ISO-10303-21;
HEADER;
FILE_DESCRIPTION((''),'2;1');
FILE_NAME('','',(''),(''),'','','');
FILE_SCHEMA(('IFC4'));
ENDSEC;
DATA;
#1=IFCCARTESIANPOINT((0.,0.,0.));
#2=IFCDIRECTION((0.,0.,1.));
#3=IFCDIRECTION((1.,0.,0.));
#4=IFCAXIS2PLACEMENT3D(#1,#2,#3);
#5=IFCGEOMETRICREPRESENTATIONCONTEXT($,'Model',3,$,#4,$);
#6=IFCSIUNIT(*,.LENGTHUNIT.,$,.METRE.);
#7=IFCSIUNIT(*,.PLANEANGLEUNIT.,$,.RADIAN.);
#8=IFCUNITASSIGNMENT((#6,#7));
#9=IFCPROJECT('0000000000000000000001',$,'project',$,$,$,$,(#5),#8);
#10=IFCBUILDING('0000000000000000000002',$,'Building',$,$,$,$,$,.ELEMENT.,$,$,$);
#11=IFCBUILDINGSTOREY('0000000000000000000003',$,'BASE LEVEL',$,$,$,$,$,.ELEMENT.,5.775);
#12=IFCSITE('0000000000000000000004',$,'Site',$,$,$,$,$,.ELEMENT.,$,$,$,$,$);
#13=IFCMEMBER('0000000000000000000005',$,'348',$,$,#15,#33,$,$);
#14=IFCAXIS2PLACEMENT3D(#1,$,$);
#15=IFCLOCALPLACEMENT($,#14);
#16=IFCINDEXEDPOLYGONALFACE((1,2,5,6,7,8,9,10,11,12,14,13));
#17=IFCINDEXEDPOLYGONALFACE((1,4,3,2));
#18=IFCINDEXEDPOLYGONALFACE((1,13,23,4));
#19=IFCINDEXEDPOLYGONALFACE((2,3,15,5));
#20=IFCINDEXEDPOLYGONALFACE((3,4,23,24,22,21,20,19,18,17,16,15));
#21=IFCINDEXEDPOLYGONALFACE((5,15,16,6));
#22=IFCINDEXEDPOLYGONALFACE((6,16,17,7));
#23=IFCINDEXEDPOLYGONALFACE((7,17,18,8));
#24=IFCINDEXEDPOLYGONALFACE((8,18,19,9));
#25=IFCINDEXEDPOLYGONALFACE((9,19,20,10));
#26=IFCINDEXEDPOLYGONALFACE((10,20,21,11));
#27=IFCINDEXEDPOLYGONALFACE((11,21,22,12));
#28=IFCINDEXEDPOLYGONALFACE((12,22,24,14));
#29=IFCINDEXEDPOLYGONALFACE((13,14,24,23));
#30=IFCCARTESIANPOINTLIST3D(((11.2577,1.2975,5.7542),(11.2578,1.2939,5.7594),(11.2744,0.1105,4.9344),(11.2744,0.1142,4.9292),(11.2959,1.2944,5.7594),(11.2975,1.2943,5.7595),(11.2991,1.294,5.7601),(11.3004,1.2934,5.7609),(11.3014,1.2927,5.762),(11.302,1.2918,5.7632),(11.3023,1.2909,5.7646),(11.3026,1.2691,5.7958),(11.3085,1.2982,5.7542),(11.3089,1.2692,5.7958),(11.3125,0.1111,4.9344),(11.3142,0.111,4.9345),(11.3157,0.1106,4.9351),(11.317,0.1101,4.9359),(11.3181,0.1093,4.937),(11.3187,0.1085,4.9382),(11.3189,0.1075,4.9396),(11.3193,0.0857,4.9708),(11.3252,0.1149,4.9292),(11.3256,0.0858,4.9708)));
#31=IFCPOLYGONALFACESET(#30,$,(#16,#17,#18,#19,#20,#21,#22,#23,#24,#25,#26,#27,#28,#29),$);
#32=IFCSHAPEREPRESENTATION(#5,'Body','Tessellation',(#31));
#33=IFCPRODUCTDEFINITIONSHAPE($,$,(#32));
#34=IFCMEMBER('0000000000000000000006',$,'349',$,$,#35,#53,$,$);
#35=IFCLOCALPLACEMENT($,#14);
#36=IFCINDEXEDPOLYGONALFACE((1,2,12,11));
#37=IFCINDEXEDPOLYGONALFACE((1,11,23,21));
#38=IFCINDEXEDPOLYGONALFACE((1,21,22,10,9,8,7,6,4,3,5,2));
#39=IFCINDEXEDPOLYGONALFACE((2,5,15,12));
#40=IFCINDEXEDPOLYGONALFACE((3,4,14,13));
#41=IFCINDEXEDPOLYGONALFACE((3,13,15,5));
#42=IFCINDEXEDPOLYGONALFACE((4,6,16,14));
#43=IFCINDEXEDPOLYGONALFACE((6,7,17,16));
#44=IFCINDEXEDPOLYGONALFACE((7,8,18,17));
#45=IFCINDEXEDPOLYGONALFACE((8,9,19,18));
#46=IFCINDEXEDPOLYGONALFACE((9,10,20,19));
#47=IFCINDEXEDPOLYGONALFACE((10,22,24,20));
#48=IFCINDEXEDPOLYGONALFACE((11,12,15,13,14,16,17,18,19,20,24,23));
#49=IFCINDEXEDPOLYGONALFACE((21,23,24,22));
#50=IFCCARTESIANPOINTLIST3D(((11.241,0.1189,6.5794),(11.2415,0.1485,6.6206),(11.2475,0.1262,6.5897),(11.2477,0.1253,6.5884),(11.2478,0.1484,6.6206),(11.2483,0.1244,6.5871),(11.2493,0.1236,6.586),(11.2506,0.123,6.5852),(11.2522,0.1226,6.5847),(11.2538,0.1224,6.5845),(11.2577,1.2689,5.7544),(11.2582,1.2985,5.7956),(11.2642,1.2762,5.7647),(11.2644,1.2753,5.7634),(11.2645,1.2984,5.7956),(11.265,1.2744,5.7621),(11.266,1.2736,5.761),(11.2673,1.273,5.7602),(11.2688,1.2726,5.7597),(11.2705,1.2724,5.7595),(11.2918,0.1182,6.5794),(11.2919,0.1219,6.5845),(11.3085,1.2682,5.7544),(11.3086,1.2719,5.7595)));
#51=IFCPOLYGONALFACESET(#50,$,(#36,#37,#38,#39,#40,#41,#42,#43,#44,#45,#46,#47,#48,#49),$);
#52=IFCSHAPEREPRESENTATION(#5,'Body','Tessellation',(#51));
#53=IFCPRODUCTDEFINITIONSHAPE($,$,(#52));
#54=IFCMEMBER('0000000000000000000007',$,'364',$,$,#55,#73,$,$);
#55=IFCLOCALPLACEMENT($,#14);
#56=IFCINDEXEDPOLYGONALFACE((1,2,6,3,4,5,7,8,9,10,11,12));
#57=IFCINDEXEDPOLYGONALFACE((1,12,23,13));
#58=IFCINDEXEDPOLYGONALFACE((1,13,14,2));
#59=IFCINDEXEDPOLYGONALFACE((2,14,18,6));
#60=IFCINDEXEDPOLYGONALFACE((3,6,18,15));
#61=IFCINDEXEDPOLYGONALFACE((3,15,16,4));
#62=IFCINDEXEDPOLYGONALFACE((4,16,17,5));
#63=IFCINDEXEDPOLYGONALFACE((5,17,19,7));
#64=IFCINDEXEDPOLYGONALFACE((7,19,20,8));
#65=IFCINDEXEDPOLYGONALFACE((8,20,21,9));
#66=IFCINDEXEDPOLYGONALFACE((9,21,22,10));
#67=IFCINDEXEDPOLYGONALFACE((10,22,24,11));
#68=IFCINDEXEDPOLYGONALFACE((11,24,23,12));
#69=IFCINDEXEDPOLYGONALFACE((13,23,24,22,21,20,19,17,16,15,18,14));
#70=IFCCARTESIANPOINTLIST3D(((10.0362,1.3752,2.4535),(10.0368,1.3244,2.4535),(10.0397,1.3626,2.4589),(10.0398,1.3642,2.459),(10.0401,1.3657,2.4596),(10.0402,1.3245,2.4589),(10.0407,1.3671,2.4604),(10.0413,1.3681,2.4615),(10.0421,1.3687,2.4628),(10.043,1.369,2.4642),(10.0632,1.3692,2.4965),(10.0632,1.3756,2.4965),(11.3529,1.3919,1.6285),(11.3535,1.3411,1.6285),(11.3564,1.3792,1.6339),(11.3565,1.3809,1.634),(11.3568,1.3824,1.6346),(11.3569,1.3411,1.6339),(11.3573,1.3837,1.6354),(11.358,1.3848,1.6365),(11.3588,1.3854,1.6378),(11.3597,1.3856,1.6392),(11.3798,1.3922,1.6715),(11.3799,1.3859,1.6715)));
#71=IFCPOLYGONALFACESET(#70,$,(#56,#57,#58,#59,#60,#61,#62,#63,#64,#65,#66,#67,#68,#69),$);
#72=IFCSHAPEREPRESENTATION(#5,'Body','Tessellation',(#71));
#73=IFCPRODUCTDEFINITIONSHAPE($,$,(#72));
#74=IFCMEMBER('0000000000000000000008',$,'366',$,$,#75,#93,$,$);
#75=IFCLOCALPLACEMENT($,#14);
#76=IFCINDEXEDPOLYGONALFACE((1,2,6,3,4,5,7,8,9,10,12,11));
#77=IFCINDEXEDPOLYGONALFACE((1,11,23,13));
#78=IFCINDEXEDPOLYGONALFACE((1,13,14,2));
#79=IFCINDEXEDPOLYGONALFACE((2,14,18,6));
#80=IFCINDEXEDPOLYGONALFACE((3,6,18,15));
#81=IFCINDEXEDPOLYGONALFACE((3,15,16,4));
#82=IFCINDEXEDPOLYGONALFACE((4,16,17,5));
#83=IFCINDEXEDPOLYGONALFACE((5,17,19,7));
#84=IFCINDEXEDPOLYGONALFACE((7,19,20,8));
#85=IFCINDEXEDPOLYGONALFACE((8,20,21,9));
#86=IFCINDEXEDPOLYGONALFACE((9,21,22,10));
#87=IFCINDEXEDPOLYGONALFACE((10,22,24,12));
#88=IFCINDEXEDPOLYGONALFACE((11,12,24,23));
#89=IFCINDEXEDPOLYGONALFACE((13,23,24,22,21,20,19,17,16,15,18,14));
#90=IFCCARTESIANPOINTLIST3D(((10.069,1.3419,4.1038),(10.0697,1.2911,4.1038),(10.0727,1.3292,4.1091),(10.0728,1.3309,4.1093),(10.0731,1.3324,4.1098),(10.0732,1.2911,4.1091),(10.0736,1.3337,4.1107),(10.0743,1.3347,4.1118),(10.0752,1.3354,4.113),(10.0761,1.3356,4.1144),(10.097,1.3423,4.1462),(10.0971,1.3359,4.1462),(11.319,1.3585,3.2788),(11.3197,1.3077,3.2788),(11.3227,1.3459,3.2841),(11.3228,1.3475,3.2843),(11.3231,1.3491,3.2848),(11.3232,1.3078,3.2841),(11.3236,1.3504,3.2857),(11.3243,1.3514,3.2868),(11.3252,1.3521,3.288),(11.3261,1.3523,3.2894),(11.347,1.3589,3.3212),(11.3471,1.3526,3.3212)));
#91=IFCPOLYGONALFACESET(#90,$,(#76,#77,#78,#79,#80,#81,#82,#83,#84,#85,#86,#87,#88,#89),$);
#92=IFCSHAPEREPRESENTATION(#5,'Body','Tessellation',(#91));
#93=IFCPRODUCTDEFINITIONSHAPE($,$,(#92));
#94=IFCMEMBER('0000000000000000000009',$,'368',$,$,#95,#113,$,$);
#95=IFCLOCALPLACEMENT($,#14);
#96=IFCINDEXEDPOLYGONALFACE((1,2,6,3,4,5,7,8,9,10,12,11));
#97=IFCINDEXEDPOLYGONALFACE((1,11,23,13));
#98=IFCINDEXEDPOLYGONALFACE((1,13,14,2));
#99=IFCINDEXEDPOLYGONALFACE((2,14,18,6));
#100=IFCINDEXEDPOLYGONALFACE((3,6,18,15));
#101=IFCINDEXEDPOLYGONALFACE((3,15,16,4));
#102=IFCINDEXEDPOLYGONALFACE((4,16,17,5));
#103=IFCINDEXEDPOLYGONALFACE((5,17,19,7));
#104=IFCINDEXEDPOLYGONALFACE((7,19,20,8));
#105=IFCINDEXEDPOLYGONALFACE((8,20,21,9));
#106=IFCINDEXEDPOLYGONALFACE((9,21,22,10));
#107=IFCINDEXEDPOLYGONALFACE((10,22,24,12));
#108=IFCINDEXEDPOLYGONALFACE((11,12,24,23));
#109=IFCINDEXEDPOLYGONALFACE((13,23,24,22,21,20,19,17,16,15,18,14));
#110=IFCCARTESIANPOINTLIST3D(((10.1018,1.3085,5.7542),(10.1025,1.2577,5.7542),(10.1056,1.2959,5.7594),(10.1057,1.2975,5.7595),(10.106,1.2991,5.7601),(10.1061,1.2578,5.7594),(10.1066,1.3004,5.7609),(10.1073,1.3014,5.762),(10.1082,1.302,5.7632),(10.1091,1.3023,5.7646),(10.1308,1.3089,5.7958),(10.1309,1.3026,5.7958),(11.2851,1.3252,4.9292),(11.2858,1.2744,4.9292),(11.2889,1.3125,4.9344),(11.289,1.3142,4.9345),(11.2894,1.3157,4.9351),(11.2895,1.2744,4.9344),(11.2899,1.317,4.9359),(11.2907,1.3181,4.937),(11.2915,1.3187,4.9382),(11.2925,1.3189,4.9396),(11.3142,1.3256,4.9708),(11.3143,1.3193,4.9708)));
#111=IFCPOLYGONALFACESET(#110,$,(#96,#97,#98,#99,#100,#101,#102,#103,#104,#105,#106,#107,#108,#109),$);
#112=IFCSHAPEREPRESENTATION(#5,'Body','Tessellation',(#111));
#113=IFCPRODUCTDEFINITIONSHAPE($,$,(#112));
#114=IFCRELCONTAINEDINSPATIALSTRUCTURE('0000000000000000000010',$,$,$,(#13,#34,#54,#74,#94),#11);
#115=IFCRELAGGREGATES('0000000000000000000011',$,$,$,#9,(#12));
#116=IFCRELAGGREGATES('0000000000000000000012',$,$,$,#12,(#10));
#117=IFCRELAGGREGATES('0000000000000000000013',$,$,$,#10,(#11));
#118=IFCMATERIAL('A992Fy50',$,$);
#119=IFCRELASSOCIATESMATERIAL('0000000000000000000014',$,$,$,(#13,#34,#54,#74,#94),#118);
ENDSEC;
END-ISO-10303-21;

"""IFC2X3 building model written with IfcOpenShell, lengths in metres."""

from ifc_helpers import new_model, si_unit, frame, origin_with_axes, origin_2d_with_axis, place, context, project, spatial, l_section, extrude, material, element, save


model = new_model("IFC2X3")

# Units and contexts
model_context = context("Model", 3, world=origin_with_axes())
ifc_project = project(units=[si_unit("LENGTHUNIT", "METRE"), si_unit("PLANEANGLEUNIT", "RADIAN")], contexts=[model_context])

# Site, building, storey
site = spatial("IfcSite", under=ifc_project, Name="Site", CompositionType="ELEMENT")
building = spatial("IfcBuilding", under=site, Name="Building", CompositionType="ELEMENT")
storey = spatial("IfcBuildingStorey", under=building, Name="BASE LEVEL", CompositionType="ELEMENT", Elevation=5.775)

# Members
ifc_material = material(Name="A992Fy50")
member_1_placement = place(None, frame((11.3, 0.1, 4.95), z_axis=(-0.011553, 0.820261, 0.571872), x_axis=(-0.999889, -0.014924, 0.0)))
element("IfcMember", 1, at=member_1_placement, inside=storey, material=ifc_material, Name="348", context=model_context, shape_type="SweptSolid", body=[
    extrude(l_section(Depth=0.0508, Width=0.0508, Thickness=0.0063, FilletRadius=0.0063, at=origin_2d_with_axis()), origin_with_axes(), (0.0, 0.0, 1.0), 1.4426),
])
member_2_placement = place(None, frame((11.2833, 1.2833, 5.775), z_axis=(-0.011775, -0.812482, 0.582867), x_axis=(0.999882, -0.015383, 0.0)))
element("IfcMember", 2, at=member_2_placement, inside=storey, material=ifc_material, Name="349", context=model_context, shape_type="SweptSolid", body=[
    extrude(l_section(Depth=0.0508, Width=0.0508, Thickness=0.0063, FilletRadius=0.0063, at=origin_2d_with_axis()), origin_with_axes(), (0.0, 0.0, 1.0), 1.4154),
])
member_3_placement = place(None, frame((11.3667, 1.3667, 1.65), z_axis=(-0.847346, -0.010726, 0.530932), x_axis=(0.013332, -0.999911, 0.0)))
element("IfcMember", 3, at=member_3_placement, inside=storey, material=ifc_material, Name="364", context=model_context, shape_type="SweptSolid", body=[
    extrude(l_section(Depth=0.0508, Width=0.0508, Thickness=0.0063, FilletRadius=0.0063, at=origin_2d_with_axis()), origin_with_axes(), (0.0, 0.0, 1.0), 1.5539),
])
member_4_placement = place(None, frame((11.3333, 1.3333, 3.3), z_axis=(-0.834558, -0.011127, 0.550808), x_axis=(0.013332, -0.999911, 0.0)))
element("IfcMember", 4, at=member_4_placement, inside=storey, material=ifc_material, Name="366", context=model_context, shape_type="SweptSolid", body=[
    extrude(l_section(Depth=0.0508, Width=0.0508, Thickness=0.0063, FilletRadius=0.0063, at=origin_2d_with_axis()), origin_with_axes(), (0.0, 0.0, 1.0), 1.4978),
])
member_5_placement = place(None, frame((11.3, 1.3, 4.95), z_axis=(-0.820261, -0.011553, 0.571872), x_axis=(0.014083, -0.999901, 0.0)))
element("IfcMember", 5, at=member_5_placement, inside=storey, material=ifc_material, Name="368", context=model_context, shape_type="SweptSolid", body=[
    extrude(l_section(Depth=0.0508, Width=0.0508, Thickness=0.0063, FilletRadius=0.0063, at=origin_2d_with_axis()), origin_with_axes(), (0.0, 0.0, 1.0), 1.4426),
])

save(model, "model.ifc")
